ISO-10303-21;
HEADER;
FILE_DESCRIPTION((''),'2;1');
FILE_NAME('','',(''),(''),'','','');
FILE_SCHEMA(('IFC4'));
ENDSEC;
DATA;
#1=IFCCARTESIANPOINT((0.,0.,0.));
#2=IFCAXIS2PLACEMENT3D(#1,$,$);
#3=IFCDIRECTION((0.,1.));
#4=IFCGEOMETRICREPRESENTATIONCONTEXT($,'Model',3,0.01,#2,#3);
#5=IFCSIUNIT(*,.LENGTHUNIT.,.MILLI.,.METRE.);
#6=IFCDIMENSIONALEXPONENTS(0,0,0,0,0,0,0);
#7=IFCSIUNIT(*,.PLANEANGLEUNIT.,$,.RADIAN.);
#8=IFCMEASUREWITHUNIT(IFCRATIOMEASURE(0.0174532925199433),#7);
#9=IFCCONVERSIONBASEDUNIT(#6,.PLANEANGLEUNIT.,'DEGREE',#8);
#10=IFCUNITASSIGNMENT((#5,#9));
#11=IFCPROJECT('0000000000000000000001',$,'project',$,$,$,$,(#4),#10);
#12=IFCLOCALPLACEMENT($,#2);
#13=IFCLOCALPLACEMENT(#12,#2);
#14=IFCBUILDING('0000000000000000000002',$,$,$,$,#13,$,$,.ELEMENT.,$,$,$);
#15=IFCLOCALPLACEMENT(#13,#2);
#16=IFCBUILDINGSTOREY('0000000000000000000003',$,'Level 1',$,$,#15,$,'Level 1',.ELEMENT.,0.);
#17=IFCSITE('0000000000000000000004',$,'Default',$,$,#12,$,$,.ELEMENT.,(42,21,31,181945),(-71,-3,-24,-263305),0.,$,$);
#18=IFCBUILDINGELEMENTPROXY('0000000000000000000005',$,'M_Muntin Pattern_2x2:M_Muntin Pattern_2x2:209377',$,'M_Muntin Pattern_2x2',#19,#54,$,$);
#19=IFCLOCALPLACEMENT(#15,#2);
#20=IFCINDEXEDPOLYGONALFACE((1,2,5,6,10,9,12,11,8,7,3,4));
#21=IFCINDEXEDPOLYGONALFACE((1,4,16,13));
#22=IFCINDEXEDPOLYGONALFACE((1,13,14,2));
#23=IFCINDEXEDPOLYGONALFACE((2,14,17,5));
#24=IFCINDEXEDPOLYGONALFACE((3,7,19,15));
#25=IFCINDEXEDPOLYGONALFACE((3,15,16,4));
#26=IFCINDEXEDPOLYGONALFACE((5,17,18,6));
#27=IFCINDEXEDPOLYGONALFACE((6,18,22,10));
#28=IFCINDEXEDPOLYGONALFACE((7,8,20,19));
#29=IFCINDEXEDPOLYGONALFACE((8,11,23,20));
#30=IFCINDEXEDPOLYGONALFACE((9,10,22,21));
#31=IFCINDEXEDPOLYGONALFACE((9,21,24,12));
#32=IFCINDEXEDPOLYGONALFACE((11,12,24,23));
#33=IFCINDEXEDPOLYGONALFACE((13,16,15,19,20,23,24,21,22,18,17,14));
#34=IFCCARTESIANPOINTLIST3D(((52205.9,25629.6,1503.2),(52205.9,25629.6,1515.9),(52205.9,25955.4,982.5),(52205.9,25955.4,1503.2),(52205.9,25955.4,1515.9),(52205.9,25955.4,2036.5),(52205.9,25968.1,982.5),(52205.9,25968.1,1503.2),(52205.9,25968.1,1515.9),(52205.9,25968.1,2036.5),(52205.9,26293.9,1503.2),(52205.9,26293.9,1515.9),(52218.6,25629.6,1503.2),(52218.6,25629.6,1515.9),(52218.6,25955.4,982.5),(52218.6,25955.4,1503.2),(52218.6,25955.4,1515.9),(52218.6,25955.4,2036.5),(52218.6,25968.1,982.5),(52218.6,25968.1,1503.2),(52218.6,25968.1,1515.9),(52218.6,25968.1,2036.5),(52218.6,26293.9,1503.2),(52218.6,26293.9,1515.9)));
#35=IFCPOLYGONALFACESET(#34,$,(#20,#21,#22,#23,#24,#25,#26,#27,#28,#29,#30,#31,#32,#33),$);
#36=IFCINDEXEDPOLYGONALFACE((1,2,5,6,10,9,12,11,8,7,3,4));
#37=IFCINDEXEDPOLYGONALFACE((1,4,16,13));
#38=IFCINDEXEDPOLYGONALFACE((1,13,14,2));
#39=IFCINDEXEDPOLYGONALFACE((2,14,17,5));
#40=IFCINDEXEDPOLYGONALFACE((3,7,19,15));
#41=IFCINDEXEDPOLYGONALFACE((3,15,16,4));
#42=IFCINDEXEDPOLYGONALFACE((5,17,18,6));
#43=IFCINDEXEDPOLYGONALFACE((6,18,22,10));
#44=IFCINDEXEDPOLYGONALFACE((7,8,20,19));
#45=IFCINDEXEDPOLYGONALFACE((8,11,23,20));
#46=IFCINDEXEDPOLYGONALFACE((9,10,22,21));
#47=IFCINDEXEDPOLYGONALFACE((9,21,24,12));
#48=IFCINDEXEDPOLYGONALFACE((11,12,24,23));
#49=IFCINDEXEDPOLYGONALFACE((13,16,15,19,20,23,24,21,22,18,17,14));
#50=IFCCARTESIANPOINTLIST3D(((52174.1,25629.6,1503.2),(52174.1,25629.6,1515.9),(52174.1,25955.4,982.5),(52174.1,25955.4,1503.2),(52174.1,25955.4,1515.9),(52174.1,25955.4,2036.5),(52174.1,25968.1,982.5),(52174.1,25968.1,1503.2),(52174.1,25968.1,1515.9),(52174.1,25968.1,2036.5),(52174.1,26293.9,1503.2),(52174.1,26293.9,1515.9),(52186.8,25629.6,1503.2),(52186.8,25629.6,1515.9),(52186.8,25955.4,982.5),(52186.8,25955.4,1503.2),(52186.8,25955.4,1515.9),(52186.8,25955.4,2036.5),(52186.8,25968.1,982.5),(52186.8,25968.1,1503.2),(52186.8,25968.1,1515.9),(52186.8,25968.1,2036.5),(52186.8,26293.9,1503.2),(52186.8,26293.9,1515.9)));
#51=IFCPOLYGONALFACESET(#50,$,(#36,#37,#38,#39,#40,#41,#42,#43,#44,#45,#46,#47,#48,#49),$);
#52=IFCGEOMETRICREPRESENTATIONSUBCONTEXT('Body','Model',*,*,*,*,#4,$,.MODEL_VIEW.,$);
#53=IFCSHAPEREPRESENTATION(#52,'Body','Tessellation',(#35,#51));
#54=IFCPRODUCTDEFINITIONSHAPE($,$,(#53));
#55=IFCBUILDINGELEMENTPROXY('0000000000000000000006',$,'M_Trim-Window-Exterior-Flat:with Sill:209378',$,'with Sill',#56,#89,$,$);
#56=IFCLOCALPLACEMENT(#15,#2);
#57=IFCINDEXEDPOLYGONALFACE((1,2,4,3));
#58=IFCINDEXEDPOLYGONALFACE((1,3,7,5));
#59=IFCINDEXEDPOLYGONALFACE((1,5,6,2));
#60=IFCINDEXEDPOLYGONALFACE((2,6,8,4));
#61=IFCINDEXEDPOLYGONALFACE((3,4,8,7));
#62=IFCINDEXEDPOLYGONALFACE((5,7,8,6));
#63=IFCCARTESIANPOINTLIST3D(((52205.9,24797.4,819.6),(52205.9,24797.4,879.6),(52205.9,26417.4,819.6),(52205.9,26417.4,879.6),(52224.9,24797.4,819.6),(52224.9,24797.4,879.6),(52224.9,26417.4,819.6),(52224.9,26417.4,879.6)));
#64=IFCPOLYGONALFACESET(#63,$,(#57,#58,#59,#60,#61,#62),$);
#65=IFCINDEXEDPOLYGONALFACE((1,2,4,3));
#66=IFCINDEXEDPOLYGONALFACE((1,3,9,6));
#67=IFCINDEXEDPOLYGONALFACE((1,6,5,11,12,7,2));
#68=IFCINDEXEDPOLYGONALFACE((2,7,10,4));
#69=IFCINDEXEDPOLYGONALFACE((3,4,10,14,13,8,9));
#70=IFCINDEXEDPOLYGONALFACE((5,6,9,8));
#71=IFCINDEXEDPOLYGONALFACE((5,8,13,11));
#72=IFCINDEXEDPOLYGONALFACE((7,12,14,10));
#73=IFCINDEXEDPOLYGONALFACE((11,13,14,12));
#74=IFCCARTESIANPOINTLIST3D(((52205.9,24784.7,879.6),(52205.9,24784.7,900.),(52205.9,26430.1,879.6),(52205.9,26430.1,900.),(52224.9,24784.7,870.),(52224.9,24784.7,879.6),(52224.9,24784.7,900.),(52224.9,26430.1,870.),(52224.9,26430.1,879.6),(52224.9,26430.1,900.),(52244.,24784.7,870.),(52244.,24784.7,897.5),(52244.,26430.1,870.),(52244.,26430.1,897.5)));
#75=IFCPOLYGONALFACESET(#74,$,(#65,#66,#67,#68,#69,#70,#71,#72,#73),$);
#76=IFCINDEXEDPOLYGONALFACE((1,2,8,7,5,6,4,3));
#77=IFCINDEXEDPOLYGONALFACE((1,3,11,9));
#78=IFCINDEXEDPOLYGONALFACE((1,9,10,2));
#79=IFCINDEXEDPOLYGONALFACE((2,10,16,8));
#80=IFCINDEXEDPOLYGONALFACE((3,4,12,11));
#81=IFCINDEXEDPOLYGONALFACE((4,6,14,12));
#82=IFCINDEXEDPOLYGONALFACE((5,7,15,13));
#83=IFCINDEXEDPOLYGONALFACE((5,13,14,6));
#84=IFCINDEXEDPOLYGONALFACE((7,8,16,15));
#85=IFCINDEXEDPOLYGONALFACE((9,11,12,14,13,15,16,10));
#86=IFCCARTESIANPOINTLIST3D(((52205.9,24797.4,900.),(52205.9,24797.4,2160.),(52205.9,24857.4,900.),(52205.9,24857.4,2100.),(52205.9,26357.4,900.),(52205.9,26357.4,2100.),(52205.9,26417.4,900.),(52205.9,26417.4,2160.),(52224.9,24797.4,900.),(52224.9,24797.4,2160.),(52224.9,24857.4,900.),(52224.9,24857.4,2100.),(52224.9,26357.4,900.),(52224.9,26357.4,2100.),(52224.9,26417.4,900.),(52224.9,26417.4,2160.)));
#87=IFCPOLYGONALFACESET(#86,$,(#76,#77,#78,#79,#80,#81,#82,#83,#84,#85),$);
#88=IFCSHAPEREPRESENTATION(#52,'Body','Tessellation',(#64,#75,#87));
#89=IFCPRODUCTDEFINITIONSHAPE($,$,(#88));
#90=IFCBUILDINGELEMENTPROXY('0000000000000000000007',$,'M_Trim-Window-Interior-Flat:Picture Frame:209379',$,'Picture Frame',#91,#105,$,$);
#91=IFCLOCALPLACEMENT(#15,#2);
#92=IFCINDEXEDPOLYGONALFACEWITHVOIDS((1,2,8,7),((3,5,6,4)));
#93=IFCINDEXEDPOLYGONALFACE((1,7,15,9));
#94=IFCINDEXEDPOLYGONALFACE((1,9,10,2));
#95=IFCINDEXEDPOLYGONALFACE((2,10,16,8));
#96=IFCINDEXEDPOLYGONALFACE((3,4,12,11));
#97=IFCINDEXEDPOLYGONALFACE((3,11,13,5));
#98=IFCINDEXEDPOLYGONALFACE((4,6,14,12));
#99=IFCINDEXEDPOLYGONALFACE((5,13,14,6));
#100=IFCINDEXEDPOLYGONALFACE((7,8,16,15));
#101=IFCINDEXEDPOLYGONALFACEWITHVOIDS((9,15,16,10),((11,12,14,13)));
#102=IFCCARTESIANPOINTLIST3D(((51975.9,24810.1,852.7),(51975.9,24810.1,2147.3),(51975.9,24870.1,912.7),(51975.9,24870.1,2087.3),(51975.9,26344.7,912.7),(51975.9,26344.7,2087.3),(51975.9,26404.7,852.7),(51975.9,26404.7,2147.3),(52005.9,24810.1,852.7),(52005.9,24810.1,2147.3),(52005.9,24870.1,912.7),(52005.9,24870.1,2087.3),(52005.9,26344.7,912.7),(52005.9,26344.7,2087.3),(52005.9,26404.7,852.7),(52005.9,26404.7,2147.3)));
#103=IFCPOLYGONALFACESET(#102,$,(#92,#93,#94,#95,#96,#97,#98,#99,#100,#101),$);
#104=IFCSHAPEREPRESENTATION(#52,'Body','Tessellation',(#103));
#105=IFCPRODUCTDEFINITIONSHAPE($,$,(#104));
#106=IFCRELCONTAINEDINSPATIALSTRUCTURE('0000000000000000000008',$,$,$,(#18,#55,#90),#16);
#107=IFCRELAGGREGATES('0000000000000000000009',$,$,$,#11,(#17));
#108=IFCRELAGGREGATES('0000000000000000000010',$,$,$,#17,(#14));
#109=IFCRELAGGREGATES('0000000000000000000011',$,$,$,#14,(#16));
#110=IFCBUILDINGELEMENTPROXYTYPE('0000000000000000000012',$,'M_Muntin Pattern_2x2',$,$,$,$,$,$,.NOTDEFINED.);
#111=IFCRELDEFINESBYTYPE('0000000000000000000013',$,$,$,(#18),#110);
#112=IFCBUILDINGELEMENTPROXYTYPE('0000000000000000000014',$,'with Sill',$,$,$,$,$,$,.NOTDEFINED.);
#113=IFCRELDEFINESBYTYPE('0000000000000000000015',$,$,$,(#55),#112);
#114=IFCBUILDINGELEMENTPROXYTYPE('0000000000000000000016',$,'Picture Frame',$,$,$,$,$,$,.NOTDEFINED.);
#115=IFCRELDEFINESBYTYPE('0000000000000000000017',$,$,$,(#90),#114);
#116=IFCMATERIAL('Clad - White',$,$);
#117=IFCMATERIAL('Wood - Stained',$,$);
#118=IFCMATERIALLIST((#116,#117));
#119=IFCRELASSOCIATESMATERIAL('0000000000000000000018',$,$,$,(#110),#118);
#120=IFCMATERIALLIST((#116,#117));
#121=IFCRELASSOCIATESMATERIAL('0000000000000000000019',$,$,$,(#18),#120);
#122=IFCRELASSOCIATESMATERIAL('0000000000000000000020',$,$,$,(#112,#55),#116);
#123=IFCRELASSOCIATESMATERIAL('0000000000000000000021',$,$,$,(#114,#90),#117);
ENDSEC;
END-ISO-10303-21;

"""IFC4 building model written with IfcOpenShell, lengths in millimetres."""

from ifc_helpers import new_model, entity, si_unit, converted_unit, direction, frame, frame_2d, origin, place, context, subcontext, project, spatial, polyline, rectangle, outline, extrude, source, transform, mapped, material, material_list, type_object, type_shapes, element, save


model = new_model("IFC4")

# Units and contexts
model_context = context("Model", 3, precision=0.01, world=origin(), true_north=direction((0.0, 1.0)))
body_context = subcontext(model_context, "Body", "Model", "MODEL_VIEW")
ifc_project = project(units=[si_unit("LENGTHUNIT", "METRE", prefix="MILLI"), converted_unit("PLANEANGLEUNIT", "DEGREE", entity("IfcRatioMeasure", 0.0174532925199433), si_unit("PLANEANGLEUNIT", "RADIAN"), dimensions=[0, 0, 0, 0, 0, 0, 0])], contexts=[model_context])

# Site, building, storey
site_placement = place(None, origin())
site = spatial("IfcSite", under=ifc_project, at=site_placement, Name="Default", CompositionType="ELEMENT", RefLatitude=(42, 21, 31, 181945), RefLongitude=(-71, -3, -24, -263305), RefElevation=0.0)
building_placement = place(site_placement, origin())
building = spatial("IfcBuilding", under=site, at=building_placement, CompositionType="ELEMENT")
storey_placement = place(building_placement, origin())
storey = spatial("IfcBuildingStorey", under=building, at=storey_placement, Name="Level 1", LongName="Level 1", CompositionType="ELEMENT", Elevation=0.0)

# Building element proxies
ifc_material_1 = material(Name="Clad - White")
ifc_material_2 = material(Name="Wood - Stained")
ifc_material_list_1 = material_list([ifc_material_1, ifc_material_2])
building_element_proxy_type_1 = type_object("IfcBuildingElementProxyType", Name="M_Muntin Pattern_2x2", PredefinedType="NOTDEFINED", material=ifc_material_list_1)
shared_shape_1 = source(origin(), body_context, "Body", "SweptSolid", [
    extrude(outline(polyline([(6.4, -6.4), (527.0, -6.4), (527.0, 6.3), (6.4, 6.3), (6.4, 332.1), (-6.3, 332.1), (-6.3, 6.3), (-527.0, 6.3), (-527.0, -6.4), (-6.3, -6.4), (-6.3, -332.1), (6.4, -332.1), (6.4, -6.4)])), frame((0.0, 9.5, 527.0), z_axis=(0.0, 1.0, 0.0), x_axis=(0.0, 0.0, 1.0)), (0.0, 0.0, 1.0), 12.7),
    extrude(outline(polyline([(6.4, -6.4), (527.0, -6.4), (527.0, 6.3), (6.4, 6.3), (6.4, 332.1), (-6.3, 332.1), (-6.3, 6.3), (-527.0, 6.3), (-527.0, -6.4), (-6.3, -6.4), (-6.3, -332.1), (6.4, -332.1), (6.4, -6.4)])), frame((0.0, -22.2, 527.0), z_axis=(0.0, 1.0, 0.0), x_axis=(0.0, 0.0, 1.0)), (0.0, 0.0, 1.0), 12.7),
])
type_shapes(building_element_proxy_type_1, [shared_shape_1])
ifc_material_list_2 = material_list([ifc_material_1, ifc_material_2])
proxy_1_placement = place(storey_placement, frame((52196.4, 25961.7, 982.5), z_axis=(0.0, 0.0, 1.0), x_axis=(0.0, -1.0, 0.0)))
element("IfcBuildingElementProxy", 1, at=proxy_1_placement, inside=storey, type_object=building_element_proxy_type_1, material=ifc_material_list_2, Name="M_Muntin Pattern_2x2:M_Muntin Pattern_2x2:209377", ObjectType="M_Muntin Pattern_2x2", context=body_context, shape_type="MappedRepresentation", body=[
    mapped(shared_shape_1, transform((0.0, 0.0, 0.0), scale=1.0)),
])
building_element_proxy_type_2 = type_object("IfcBuildingElementProxyType", Name="with Sill", PredefinedType="NOTDEFINED", material=ifc_material_1)
shared_shape_2 = source(origin(), body_context, "Body", "SweptSolid", [
    extrude(rectangle(XDim=1620.0, YDim=60.0, at=frame_2d((0.0, 0.0), x_axis=(1.0, 0.0))), frame((0.0, -1250.4, 0.0), z_axis=(0.0, 0.0, 1.0), x_axis=(-1.0, 0.0, 0.0)), (0.0, 0.0, 1.0), 19.1),
    extrude(outline(polyline([(-19.0, -15.2), (0.0, -15.2), (0.0, -5.7), (19.0, -5.7), (19.0, 14.8), (0.0, 14.8), (-19.0, 12.3), (-19.0, -15.2)])), frame((-822.7, -1214.8, 19.0), z_axis=(1.0, 0.0, 0.0), x_axis=(0.0, 0.0, -1.0)), (0.0, 0.0, 1.0), 1645.4),
    extrude(outline(polyline([(-645.0, -810.0), (615.0, -810.0), (615.0, -750.0), (-585.0, -750.0), (-585.0, 750.0), (615.0, 750.0), (615.0, 810.0), (-645.0, 810.0), (-645.0, -810.0)])), frame((0.0, -585.0, 0.0), z_axis=(0.0, 0.0, 1.0), x_axis=(0.0, -1.0, 0.0)), (0.0, 0.0, 1.0), 19.1),
])
type_shapes(building_element_proxy_type_2, [shared_shape_2])
proxy_2_placement = place(storey_placement, frame((52205.9, 25607.4, 2100.0), z_axis=(1.0, 0.0, 0.0), x_axis=(0.0, 1.0, 0.0)))
element("IfcBuildingElementProxy", 2, at=proxy_2_placement, inside=storey, type_object=building_element_proxy_type_2, material=ifc_material_1, Name="M_Trim-Window-Exterior-Flat:with Sill:209378", ObjectType="with Sill", context=body_context, shape_type="MappedRepresentation", body=[
    mapped(shared_shape_2, transform((0.0, 0.0, 0.0), scale=1.0)),
])
building_element_proxy_type_3 = type_object("IfcBuildingElementProxyType", Name="Picture Frame", PredefinedType="NOTDEFINED", material=ifc_material_2)
shared_shape_3 = source(origin(), body_context, "Body", "SweptSolid", [
    extrude(outline(polyline([(-797.3, -647.3), (797.3, -647.3), (797.3, 647.3), (-797.3, 647.3), (-797.3, -647.3)]), holes=[polyline([(-737.3, -587.3), (-737.3, 587.3), (737.3, 587.3), (737.3, -587.3), (-737.3, -587.3)])]), frame((0.0, -600.0, 0.0), z_axis=(0.0, 0.0, 1.0), x_axis=(-1.0, 0.0, 0.0)), (0.0, 0.0, 1.0), 30.0),
])
type_shapes(building_element_proxy_type_3, [shared_shape_3])
proxy_3_placement = place(storey_placement, frame((52005.9, 25607.4, 2100.0), z_axis=(-1.0, 0.0, 0.0), x_axis=(0.0, -1.0, 0.0)))
element("IfcBuildingElementProxy", 3, at=proxy_3_placement, inside=storey, type_object=building_element_proxy_type_3, material=ifc_material_2, Name="M_Trim-Window-Interior-Flat:Picture Frame:209379", ObjectType="Picture Frame", context=body_context, shape_type="MappedRepresentation", body=[
    mapped(shared_shape_3, transform((0.0, 0.0, 0.0), scale=1.0)),
])

save(model, "model.ifc")
